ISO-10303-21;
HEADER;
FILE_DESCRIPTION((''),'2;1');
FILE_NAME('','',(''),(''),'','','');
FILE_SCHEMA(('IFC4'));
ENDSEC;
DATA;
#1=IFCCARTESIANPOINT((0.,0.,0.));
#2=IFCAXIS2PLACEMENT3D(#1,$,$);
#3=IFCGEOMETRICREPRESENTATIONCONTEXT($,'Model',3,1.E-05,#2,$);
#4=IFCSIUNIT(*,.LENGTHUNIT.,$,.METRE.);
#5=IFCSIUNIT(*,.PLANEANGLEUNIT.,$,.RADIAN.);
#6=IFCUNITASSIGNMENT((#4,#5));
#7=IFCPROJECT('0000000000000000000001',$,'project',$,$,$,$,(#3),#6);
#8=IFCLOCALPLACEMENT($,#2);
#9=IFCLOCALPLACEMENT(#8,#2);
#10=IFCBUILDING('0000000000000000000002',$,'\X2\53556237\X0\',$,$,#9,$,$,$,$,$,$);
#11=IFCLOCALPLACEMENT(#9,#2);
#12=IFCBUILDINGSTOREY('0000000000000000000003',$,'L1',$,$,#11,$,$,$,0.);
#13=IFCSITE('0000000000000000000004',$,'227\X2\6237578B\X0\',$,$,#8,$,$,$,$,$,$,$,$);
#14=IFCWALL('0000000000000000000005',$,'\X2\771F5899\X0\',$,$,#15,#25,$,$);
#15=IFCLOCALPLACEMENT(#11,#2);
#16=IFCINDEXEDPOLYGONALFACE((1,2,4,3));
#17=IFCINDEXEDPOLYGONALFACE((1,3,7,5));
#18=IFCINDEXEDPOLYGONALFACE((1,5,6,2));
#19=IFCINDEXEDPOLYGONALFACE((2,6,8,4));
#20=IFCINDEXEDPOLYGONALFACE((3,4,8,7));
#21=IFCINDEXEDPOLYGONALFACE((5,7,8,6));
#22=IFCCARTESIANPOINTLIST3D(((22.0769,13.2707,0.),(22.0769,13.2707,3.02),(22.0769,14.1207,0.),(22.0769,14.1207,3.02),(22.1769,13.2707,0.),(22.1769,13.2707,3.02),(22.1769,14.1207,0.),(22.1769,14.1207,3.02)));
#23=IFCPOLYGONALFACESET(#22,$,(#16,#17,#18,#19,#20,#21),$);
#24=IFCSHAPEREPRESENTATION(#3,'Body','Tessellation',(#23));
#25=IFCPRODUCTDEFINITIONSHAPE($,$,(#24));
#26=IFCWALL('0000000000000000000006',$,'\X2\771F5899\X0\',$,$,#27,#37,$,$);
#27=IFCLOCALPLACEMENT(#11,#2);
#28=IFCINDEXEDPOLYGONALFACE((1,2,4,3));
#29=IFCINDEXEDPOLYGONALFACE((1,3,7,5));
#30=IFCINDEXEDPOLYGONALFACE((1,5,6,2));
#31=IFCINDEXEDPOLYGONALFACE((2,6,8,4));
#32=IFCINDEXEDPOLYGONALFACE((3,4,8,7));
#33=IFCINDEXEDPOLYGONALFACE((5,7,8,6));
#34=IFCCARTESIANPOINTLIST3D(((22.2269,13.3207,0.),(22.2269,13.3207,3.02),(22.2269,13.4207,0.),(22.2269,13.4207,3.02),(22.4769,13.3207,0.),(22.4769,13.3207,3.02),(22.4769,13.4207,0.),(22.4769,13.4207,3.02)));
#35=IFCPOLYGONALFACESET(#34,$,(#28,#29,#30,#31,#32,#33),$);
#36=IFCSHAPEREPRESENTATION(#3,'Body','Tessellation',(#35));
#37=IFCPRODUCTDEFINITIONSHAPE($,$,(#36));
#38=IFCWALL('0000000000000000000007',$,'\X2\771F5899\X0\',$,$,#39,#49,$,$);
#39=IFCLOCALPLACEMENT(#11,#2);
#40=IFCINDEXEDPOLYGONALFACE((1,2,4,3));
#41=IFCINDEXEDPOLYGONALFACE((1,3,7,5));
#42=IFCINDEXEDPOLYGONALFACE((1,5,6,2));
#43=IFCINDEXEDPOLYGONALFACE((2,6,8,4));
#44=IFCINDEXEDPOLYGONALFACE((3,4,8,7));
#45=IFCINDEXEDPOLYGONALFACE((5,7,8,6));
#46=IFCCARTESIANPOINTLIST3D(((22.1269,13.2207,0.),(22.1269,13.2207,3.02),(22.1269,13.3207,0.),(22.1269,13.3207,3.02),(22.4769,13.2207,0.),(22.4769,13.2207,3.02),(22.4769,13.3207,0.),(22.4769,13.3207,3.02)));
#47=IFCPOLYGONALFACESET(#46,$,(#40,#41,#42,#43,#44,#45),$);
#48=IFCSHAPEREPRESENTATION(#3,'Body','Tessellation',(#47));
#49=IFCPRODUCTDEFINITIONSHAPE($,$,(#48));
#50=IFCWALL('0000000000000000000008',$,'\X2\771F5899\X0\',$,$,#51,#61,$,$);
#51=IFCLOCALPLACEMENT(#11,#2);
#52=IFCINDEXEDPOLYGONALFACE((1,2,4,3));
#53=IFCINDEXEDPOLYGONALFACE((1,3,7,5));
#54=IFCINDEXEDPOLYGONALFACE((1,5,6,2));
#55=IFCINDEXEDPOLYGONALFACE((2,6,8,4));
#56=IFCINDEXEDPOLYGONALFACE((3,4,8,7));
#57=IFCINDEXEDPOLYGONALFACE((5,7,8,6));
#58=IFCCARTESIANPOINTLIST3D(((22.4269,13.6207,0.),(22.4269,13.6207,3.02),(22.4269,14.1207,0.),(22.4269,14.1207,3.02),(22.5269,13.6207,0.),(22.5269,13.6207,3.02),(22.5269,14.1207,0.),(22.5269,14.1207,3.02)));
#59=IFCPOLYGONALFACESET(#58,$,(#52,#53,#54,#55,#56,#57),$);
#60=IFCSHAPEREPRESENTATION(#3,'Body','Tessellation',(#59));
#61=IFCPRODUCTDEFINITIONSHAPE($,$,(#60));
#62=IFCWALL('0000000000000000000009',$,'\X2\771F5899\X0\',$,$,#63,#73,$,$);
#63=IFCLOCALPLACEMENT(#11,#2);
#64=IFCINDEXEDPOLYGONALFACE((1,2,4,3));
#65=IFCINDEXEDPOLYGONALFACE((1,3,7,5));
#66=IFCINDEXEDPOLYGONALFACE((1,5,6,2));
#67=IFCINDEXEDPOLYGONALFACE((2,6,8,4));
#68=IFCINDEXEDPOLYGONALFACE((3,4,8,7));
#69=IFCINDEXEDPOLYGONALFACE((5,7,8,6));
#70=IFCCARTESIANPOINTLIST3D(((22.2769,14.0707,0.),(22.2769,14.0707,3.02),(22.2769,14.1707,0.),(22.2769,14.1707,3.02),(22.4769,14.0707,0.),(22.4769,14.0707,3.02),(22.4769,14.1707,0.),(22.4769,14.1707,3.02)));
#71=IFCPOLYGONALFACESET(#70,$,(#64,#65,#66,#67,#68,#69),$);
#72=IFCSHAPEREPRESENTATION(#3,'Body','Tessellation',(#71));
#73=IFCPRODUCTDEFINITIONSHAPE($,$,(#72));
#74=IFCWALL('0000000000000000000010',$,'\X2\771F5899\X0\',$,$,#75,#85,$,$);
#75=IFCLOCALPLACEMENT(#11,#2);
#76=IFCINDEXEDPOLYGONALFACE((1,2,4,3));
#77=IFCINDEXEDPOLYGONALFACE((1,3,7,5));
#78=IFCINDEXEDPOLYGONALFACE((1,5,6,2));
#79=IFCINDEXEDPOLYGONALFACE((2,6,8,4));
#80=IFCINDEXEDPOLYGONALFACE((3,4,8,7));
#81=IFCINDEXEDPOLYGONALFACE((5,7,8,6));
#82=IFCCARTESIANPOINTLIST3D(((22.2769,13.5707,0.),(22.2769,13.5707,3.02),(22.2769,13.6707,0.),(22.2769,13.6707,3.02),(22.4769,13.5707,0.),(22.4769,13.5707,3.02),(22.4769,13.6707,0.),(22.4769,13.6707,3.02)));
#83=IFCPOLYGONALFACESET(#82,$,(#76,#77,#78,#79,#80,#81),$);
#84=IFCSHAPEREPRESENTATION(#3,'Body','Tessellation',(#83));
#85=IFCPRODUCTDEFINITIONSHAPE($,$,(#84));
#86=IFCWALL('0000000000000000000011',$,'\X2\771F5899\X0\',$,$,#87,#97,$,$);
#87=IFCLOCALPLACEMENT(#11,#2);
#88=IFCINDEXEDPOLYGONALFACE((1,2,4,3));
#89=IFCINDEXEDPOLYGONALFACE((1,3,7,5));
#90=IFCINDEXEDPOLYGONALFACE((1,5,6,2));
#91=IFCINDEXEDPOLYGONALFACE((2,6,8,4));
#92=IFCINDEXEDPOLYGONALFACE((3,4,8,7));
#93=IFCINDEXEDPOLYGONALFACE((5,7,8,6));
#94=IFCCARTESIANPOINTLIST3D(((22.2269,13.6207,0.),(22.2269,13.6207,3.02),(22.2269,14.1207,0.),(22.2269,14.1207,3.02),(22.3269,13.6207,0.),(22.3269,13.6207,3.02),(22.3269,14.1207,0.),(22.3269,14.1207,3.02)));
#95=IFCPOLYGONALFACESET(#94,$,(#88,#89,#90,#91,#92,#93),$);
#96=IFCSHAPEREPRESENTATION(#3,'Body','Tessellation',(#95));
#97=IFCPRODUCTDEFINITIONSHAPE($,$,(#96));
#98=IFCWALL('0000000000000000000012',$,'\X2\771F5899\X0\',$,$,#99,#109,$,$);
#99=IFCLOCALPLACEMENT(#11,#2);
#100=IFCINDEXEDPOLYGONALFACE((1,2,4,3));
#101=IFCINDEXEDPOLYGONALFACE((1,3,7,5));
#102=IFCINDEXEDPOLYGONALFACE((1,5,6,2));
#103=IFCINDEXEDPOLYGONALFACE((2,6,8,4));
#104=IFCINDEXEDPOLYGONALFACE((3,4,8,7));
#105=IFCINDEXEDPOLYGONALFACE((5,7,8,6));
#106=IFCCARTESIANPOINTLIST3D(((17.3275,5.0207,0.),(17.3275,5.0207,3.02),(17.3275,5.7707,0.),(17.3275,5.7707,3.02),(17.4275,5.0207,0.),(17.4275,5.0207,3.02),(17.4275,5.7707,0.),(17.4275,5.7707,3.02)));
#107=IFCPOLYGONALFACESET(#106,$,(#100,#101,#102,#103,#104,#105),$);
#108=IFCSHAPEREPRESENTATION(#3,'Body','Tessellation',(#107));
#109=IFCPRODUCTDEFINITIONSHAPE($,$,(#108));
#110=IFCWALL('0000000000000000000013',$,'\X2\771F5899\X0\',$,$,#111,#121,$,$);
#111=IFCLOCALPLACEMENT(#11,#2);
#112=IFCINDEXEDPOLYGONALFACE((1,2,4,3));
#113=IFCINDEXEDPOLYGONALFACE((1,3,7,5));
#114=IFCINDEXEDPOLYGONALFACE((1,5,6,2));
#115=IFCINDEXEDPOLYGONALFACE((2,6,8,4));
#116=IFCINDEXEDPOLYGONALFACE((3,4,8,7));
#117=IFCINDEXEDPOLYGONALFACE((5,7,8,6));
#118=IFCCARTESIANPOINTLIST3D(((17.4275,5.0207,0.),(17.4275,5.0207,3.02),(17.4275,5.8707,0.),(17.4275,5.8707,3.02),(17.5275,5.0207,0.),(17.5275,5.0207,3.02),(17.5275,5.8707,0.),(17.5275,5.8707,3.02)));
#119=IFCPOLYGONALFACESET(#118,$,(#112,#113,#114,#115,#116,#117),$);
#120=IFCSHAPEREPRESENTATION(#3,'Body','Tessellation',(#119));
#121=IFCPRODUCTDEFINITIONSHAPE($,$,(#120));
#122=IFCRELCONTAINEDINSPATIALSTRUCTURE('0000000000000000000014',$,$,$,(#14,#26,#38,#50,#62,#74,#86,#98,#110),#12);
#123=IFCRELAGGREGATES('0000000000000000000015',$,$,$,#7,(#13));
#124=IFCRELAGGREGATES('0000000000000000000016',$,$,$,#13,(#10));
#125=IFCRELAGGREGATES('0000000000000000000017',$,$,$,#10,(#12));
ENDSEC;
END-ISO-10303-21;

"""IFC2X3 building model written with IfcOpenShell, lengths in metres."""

from ifc_helpers import new_model, si_unit, origin, place, context, project, spatial, polyline, outline, extrude, element, save


model = new_model("IFC2X3")

# Units and contexts
model_context = context("Model", 3, precision=1e-05, world=origin())
ifc_project = project(units=[si_unit("LENGTHUNIT", "METRE"), si_unit("PLANEANGLEUNIT", "RADIAN")], contexts=[model_context])

# Site, building, storey
site_placement = place(None, origin())
site = spatial("IfcSite", under=ifc_project, at=site_placement, Name="227户型")
building_placement = place(site_placement, origin())
building = spatial("IfcBuilding", under=site, at=building_placement, Name="单户")
storey_placement = place(building_placement, origin())
storey = spatial("IfcBuildingStorey", under=building, at=storey_placement, Name="L1", Elevation=0.0)

# Walls
wall_1_placement = place(storey_placement, origin())
element("IfcWall", 1, at=wall_1_placement, inside=storey, Name="真墙", context=model_context, shape_type="SweptSolid", body=[
    extrude(outline(polyline([(22.1769, 14.1207), (22.1769, 13.2707), (22.0769, 13.2707), (22.0769, 14.1207), (22.1769, 14.1207)])), origin(), (0.0, 0.0, 1.0), 3.02),
])
wall_2_placement = place(storey_placement, origin())
element("IfcWall", 2, at=wall_2_placement, inside=storey, Name="真墙", context=model_context, shape_type="SweptSolid", body=[
    extrude(outline(polyline([(22.2269, 13.4207), (22.4769, 13.4207), (22.4769, 13.3207), (22.2269, 13.3207), (22.2269, 13.4207)])), origin(), (0.0, 0.0, 1.0), 3.02),
])
wall_3_placement = place(storey_placement, origin())
element("IfcWall", 3, at=wall_3_placement, inside=storey, Name="真墙", context=model_context, shape_type="SweptSolid", body=[
    extrude(outline(polyline([(22.1269, 13.3207), (22.4769, 13.3207), (22.4769, 13.2207), (22.1269, 13.2207), (22.1269, 13.3207)])), origin(), (0.0, 0.0, 1.0), 3.02),
])
wall_4_placement = place(storey_placement, origin())
element("IfcWall", 4, at=wall_4_placement, inside=storey, Name="真墙", context=model_context, shape_type="SweptSolid", body=[
    extrude(outline(polyline([(22.4269, 13.6207), (22.4269, 14.1207), (22.5269, 14.1207), (22.5269, 13.6207), (22.4269, 13.6207)])), origin(), (0.0, 0.0, 1.0), 3.02),
])
wall_5_placement = place(storey_placement, origin())
element("IfcWall", 5, at=wall_5_placement, inside=storey, Name="真墙", context=model_context, shape_type="SweptSolid", body=[
    extrude(outline(polyline([(22.4769, 14.0707), (22.2769, 14.0707), (22.2769, 14.1707), (22.4769, 14.1707), (22.4769, 14.0707)])), origin(), (0.0, 0.0, 1.0), 3.02),
])
wall_6_placement = place(storey_placement, origin())
element("IfcWall", 6, at=wall_6_placement, inside=storey, Name="真墙", context=model_context, shape_type="SweptSolid", body=[
    extrude(outline(polyline([(22.4769, 13.5707), (22.2769, 13.5707), (22.2769, 13.6707), (22.4769, 13.6707), (22.4769, 13.5707)])), origin(), (0.0, 0.0, 1.0), 3.02),
])
wall_7_placement = place(storey_placement, origin())
element("IfcWall", 7, at=wall_7_placement, inside=storey, Name="真墙", context=model_context, shape_type="SweptSolid", body=[
    extrude(outline(polyline([(22.2269, 13.6207), (22.2269, 14.1207), (22.3269, 14.1207), (22.3269, 13.6207), (22.2269, 13.6207)])), origin(), (0.0, 0.0, 1.0), 3.02),
])
wall_8_placement = place(storey_placement, origin())
element("IfcWall", 8, at=wall_8_placement, inside=storey, Name="真墙", context=model_context, shape_type="SweptSolid", body=[
    extrude(outline(polyline([(17.4275, 5.7707), (17.4275, 5.0207), (17.3275, 5.0207), (17.3275, 5.7707), (17.4275, 5.7707)])), origin(), (0.0, 0.0, 1.0), 3.02),
])
wall_9_placement = place(storey_placement, origin())
element("IfcWall", 9, at=wall_9_placement, inside=storey, Name="真墙", context=model_context, shape_type="SweptSolid", body=[
    extrude(outline(polyline([(17.4275, 5.0207), (17.4275, 5.8707), (17.5275, 5.8707), (17.5275, 5.0207), (17.4275, 5.0207)])), origin(), (0.0, 0.0, 1.0), 3.02),
])

save(model, "model.ifc")
